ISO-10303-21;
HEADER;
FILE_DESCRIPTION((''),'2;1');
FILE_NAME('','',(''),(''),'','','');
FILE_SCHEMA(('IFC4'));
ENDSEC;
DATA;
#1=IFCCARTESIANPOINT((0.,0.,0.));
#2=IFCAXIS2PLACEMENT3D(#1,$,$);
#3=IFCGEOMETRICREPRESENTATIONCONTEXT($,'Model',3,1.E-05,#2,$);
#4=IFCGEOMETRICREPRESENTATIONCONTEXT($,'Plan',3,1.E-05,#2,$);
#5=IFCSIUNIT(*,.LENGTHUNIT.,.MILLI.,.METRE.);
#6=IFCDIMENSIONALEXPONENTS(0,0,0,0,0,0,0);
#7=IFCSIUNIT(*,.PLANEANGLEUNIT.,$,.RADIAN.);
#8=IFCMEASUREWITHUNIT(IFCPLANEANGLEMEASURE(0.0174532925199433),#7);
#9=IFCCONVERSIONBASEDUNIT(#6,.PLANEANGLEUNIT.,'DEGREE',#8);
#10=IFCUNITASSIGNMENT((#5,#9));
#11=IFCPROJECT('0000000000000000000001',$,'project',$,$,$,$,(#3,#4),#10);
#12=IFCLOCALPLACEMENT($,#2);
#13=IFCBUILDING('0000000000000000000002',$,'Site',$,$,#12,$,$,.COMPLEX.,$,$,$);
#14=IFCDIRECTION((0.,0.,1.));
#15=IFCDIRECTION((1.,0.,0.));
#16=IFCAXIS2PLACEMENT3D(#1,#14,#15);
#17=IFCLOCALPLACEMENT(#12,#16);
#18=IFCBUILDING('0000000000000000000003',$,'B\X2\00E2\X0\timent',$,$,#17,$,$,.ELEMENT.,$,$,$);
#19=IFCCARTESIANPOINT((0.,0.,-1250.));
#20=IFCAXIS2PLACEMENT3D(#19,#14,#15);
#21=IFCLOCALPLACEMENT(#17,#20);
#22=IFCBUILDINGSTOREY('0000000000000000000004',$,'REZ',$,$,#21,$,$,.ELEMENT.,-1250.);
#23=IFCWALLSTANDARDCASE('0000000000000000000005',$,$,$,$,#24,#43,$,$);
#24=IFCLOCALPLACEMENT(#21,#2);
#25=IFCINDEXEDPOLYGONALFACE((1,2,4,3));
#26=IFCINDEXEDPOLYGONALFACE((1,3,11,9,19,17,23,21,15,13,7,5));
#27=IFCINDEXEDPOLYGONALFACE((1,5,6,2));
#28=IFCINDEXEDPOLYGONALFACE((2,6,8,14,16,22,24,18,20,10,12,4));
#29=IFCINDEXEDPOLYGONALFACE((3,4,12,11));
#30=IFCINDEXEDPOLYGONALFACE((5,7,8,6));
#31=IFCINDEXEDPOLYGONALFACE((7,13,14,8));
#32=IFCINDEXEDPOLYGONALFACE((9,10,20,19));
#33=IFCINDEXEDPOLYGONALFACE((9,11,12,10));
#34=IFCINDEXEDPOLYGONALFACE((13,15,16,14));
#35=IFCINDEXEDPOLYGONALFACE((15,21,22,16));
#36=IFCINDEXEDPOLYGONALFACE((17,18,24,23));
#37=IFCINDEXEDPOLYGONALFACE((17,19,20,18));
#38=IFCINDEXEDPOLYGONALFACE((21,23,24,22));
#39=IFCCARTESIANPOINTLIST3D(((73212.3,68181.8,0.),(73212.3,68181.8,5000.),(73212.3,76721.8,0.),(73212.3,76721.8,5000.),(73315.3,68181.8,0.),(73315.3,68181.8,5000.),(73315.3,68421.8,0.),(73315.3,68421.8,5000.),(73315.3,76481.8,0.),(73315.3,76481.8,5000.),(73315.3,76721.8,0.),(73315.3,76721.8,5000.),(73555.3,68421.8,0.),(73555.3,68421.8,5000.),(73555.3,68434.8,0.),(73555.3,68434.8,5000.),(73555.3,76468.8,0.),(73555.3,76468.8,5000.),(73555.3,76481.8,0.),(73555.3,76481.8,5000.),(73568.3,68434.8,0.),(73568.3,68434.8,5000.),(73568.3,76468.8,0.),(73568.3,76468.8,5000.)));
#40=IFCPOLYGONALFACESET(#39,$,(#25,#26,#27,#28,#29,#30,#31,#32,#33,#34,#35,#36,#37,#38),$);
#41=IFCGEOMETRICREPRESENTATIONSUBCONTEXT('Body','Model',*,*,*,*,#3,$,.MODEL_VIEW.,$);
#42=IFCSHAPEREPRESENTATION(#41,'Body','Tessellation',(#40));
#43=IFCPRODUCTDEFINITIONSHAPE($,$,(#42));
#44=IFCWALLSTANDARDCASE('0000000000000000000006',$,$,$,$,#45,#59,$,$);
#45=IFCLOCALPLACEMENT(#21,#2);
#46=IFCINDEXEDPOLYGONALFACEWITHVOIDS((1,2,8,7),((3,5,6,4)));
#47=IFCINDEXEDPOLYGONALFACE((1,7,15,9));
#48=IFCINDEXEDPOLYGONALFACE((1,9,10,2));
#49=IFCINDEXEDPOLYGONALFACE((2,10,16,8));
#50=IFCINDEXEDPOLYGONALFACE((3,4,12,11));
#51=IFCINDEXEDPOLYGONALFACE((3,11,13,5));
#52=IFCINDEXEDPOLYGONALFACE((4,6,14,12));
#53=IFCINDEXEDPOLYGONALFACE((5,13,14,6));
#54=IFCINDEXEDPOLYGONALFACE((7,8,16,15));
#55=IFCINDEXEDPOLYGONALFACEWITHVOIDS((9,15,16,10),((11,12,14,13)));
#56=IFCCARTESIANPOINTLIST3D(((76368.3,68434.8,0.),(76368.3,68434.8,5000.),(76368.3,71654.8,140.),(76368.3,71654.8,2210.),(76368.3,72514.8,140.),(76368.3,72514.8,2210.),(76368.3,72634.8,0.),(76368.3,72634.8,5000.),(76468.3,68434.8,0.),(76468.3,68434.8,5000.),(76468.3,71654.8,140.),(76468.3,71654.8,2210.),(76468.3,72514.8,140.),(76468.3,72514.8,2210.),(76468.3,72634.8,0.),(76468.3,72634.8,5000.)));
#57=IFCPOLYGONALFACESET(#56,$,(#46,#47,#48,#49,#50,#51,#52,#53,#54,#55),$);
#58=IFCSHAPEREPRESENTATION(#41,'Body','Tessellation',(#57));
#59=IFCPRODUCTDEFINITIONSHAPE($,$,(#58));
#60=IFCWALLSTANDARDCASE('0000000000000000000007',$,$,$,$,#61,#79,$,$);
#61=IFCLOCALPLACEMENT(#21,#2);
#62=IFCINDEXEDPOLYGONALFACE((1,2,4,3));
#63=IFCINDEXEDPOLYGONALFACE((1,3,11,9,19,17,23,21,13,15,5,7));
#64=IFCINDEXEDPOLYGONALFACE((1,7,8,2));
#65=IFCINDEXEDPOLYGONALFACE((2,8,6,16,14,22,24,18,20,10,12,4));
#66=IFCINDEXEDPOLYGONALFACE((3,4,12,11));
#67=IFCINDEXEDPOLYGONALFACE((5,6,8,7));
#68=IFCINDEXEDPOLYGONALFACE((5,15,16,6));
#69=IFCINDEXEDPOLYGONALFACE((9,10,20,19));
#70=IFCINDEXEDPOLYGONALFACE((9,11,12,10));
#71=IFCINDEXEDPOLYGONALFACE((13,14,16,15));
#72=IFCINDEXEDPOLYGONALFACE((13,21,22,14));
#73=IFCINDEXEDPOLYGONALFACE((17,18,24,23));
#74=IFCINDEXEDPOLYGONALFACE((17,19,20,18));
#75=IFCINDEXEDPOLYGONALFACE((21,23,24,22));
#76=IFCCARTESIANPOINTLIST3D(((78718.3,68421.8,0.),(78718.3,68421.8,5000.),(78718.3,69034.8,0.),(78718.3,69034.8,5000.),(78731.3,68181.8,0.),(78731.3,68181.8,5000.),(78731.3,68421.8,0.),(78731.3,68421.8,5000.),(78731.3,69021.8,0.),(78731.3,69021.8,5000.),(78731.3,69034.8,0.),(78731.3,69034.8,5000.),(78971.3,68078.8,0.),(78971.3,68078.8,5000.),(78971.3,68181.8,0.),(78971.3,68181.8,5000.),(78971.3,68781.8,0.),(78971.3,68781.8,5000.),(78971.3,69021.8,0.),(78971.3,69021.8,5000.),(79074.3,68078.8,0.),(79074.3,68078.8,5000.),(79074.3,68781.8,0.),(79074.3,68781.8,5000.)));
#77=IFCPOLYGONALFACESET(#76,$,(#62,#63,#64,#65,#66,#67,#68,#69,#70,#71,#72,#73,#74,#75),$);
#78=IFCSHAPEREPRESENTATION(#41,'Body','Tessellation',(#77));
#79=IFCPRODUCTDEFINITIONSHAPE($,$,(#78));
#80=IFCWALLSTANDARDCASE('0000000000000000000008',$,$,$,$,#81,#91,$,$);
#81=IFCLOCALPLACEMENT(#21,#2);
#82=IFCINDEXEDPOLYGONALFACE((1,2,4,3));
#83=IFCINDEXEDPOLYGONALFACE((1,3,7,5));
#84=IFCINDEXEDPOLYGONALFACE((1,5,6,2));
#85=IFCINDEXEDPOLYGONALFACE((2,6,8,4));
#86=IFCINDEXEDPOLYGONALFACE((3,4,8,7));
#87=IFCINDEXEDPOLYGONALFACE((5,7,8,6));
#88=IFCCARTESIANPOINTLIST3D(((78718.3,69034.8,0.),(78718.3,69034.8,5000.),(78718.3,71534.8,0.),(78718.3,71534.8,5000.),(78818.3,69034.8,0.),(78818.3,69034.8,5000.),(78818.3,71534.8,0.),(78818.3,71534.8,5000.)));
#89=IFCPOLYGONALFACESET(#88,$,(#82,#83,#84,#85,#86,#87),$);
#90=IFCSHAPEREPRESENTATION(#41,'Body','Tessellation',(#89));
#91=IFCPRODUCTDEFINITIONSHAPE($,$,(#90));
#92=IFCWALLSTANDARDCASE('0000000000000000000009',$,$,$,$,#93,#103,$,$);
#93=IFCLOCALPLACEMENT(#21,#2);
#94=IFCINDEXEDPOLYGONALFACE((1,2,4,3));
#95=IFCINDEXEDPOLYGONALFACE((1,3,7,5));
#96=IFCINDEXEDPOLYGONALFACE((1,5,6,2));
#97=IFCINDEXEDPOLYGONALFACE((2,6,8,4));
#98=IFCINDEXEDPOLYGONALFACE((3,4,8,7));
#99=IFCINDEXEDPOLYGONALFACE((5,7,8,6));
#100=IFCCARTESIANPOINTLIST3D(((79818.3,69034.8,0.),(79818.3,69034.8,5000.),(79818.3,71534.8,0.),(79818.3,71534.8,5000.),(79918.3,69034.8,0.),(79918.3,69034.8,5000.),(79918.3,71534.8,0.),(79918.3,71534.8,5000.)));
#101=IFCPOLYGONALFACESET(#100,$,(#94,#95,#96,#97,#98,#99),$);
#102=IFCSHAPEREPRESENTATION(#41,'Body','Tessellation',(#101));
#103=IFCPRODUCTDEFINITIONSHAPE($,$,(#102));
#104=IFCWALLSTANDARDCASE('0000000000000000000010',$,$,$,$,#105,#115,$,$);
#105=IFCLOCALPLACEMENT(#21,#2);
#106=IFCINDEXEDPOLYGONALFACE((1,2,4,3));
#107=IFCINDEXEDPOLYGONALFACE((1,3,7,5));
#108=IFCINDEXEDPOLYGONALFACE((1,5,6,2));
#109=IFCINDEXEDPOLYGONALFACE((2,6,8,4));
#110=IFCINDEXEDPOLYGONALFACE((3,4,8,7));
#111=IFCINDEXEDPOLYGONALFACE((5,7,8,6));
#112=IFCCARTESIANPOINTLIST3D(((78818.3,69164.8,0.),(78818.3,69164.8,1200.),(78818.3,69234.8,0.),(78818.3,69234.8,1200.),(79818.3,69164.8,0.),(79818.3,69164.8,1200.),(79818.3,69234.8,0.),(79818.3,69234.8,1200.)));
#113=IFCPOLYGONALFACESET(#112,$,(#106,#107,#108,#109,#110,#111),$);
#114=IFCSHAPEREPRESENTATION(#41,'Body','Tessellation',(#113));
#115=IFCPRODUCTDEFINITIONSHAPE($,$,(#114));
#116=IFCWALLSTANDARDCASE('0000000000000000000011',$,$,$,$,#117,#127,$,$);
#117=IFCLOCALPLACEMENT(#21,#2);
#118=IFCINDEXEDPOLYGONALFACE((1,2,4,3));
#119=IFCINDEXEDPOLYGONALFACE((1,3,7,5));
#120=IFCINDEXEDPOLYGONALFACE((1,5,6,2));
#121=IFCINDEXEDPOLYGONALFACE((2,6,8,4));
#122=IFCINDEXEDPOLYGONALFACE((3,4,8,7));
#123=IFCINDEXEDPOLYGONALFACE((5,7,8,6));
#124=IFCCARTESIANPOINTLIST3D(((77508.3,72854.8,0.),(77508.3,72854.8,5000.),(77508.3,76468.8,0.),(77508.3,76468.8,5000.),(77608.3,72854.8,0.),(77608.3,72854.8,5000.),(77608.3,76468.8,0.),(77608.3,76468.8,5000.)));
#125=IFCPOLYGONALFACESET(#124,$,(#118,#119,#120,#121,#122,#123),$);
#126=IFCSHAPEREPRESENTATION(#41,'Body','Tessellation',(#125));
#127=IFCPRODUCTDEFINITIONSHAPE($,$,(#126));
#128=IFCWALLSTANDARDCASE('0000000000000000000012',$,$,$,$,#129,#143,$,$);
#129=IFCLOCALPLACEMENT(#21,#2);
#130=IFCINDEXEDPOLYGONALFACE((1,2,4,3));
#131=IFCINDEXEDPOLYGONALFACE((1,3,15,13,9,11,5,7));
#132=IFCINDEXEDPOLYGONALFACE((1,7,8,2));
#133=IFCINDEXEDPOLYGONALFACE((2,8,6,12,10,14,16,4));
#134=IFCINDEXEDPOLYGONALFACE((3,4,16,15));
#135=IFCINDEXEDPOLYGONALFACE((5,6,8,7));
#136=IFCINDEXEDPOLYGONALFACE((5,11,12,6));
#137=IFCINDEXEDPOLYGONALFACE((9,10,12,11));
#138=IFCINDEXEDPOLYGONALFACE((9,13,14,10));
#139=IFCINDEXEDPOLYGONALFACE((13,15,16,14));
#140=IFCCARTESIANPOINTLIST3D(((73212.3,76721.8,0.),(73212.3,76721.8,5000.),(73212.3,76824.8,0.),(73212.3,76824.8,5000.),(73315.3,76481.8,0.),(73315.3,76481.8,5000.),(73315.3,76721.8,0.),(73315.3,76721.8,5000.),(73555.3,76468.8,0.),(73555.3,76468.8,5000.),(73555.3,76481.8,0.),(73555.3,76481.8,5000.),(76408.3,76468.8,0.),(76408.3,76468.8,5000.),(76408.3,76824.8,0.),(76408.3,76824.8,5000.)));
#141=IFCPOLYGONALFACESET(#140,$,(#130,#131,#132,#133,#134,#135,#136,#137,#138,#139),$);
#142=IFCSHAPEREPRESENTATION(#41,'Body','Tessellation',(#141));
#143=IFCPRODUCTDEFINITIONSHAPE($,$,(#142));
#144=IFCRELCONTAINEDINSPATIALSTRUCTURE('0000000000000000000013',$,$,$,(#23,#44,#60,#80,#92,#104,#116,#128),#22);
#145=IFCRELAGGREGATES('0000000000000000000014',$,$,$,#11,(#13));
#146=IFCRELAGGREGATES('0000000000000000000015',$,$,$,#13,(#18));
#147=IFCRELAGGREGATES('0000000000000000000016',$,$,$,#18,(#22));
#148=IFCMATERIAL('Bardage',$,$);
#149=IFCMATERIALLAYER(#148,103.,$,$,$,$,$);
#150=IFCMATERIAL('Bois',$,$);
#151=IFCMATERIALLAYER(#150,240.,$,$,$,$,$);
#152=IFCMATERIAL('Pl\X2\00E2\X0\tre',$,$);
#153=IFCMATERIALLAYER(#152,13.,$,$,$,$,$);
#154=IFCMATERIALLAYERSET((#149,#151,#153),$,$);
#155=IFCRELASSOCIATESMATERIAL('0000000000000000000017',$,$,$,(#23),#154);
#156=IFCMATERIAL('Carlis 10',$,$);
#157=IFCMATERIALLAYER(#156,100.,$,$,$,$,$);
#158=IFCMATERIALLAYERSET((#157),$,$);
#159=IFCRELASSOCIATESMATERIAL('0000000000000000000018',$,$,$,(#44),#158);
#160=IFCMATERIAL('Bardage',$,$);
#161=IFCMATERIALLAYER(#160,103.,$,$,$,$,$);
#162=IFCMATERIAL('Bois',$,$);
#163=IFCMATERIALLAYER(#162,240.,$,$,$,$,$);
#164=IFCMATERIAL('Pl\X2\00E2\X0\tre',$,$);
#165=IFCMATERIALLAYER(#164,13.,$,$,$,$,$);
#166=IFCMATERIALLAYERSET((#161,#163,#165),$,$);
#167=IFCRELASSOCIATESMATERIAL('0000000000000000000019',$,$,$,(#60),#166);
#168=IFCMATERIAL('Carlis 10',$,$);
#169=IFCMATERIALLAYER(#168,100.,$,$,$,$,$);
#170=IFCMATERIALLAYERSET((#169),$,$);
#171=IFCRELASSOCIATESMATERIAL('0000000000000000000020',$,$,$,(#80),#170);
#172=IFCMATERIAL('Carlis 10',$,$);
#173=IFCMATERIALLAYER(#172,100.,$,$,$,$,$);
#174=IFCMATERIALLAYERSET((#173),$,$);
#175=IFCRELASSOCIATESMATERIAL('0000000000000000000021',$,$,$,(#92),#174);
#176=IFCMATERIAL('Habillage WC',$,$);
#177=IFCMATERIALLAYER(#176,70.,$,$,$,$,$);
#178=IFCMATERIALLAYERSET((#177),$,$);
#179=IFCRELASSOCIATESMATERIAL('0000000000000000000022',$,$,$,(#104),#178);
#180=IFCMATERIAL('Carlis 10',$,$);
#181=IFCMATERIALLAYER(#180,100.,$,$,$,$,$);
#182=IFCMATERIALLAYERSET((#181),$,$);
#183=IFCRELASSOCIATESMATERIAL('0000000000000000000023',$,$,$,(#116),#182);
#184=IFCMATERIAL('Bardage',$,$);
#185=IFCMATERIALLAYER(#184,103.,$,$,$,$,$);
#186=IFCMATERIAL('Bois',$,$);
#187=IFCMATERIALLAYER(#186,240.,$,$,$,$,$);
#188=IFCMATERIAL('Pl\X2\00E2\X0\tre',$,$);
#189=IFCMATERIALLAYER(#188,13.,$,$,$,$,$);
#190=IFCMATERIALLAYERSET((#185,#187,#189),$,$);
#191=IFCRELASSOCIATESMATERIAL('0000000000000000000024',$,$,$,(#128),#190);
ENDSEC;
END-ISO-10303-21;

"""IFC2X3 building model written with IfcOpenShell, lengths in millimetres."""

from ifc_helpers import new_model, entity, si_unit, converted_unit, frame, frame_2d, origin, origin_with_axes, place, context, subcontext, project, spatial, polyline, rectangle, outline, extrude, material, layer, layer_set, layer_usage, element, save


model = new_model("IFC2X3")

# Units and contexts
model_context = context("Model", 3, precision=1e-05, world=origin())
plan_context = context("Plan", 3, precision=1e-05, world=origin())
body_context = subcontext(model_context, "Body", "Model", "MODEL_VIEW")
ifc_project = project(units=[si_unit("LENGTHUNIT", "METRE", prefix="MILLI"), converted_unit("PLANEANGLEUNIT", "DEGREE", entity("IfcPlaneAngleMeasure", 0.0174532925199433), si_unit("PLANEANGLEUNIT", "RADIAN"), dimensions=[0, 0, 0, 0, 0, 0, 0])], contexts=[model_context, plan_context])

# Buildings, storey
building_1_placement = place(None, origin())
building_1 = spatial("IfcBuilding", under=ifc_project, at=building_1_placement, Name="Site", CompositionType="COMPLEX")
building_2_placement = place(building_1_placement, origin_with_axes())
building_2 = spatial("IfcBuilding", under=building_1, at=building_2_placement, Name="Bâtiment", CompositionType="ELEMENT")
storey_placement = place(building_2_placement, frame((0.0, 0.0, -1250.0), z_axis=(0.0, 0.0, 1.0), x_axis=(1.0, 0.0, 0.0)))
storey = spatial("IfcBuildingStorey", under=building_2, at=storey_placement, Name="REZ", CompositionType="ELEMENT", Elevation=-1250.0)

# Wall
ifc_material_1 = material(Name="Bardage")
ifc_layer_1 = layer(ifc_material_1, 103.0)
ifc_material_2 = material(Name="Bois")
ifc_layer_2 = layer(ifc_material_2, 240.0)
ifc_material_3 = material(Name="Plâtre")
ifc_layer_3 = layer(ifc_material_3, 13.0)
ifc_layer_set_1 = layer_set([ifc_layer_1, ifc_layer_2, ifc_layer_3])
ifc_layer_usage_1 = layer_usage(ifc_layer_set_1, "AXIS2", "POSITIVE", 0.0)
wall_1_placement = place(storey_placement, frame((73212.3, 76721.8, 0.0), z_axis=(0.0, 0.0, 1.0), x_axis=(0.0, -1.0, 0.0)))
element("IfcWallStandardCase", 1, at=wall_1_placement, inside=storey, material=ifc_layer_usage_1, context=body_context, shape_type="SweptSolid", body=[
    extrude(outline(polyline([(0.0, 0.0), (8540.0, 0.0), (8540.0, 103.0), (8300.0, 103.0), (8300.0, 343.0), (8287.0, 343.0), (8287.0, 356.0), (253.0, 356.0), (253.0, 343.0), (240.0, 343.0), (240.0, 103.0), (0.0, 103.0), (0.0, 0.0)])), origin_with_axes(), (0.0, 0.0, 1.0), 5000.0),
])

# Wall, opening
ifc_material_4 = material(Name="Carlis 10")
ifc_layer_4 = layer(ifc_material_4, 100.0)
ifc_layer_set_2 = layer_set([ifc_layer_4])
ifc_layer_usage_2 = layer_usage(ifc_layer_set_2, "AXIS2", "POSITIVE", 0.0)
wall_2_placement = place(storey_placement, frame((76368.3, 72634.8, 0.0), z_axis=(0.0, 0.0, 1.0), x_axis=(0.0, -1.0, 0.0)))
wall_2 = element("IfcWallStandardCase", 2, at=wall_2_placement, inside=storey, material=ifc_layer_usage_2, context=body_context, shape_type="SweptSolid", body=[
    extrude(rectangle(XDim=4200.0, YDim=100.0, at=frame_2d((2100.0, 50.0), x_axis=(1.0, 0.0))), origin_with_axes(), (0.0, 0.0, 1.0), 5000.0),
])
opening_1_placement = place(wall_2_placement, frame((120.0, 0.0, 140.0), z_axis=(0.0, 1.0, 0.0), x_axis=(0.0, 0.0, 1.0)))
element("IfcOpeningElement", 3, at=opening_1_placement, cuts=wall_2, ObjectType="Opening", context=body_context, shape_type="SweptSolid", body=[
    extrude(rectangle(XDim=2070.0, YDim=860.0, at=frame_2d((1035.0, 430.0), x_axis=(1.0, 0.0))), origin_with_axes(), (0.0, 0.0, 1.0), 100.0),
])

# Walls
ifc_material_5 = material(Name="Bardage")
ifc_layer_5 = layer(ifc_material_5, 103.0)
ifc_material_6 = material(Name="Bois")
ifc_layer_6 = layer(ifc_material_6, 240.0)
ifc_material_7 = material(Name="Plâtre")
ifc_layer_7 = layer(ifc_material_7, 13.0)
ifc_layer_set_3 = layer_set([ifc_layer_5, ifc_layer_6, ifc_layer_7])
ifc_layer_usage_3 = layer_usage(ifc_layer_set_3, "AXIS2", "POSITIVE", 0.0)
wall_3_placement = place(storey_placement, frame((79074.3, 68078.8, 0.0), z_axis=(0.0, 0.0, 1.0), x_axis=(0.0, 1.0, 0.0)))
element("IfcWallStandardCase", 4, at=wall_3_placement, inside=storey, material=ifc_layer_usage_3, context=body_context, shape_type="SweptSolid", body=[
    extrude(outline(polyline([(0.0, 0.0), (703.0, 0.0), (703.0, 103.0), (943.0, 103.0), (943.0, 343.0), (956.0, 343.0), (956.0, 356.0), (343.0, 356.0), (343.0, 343.0), (103.0, 343.0), (103.0, 103.0), (0.0, 103.0), (0.0, 0.0)])), origin_with_axes(), (0.0, 0.0, 1.0), 5000.0),
])
ifc_material_8 = material(Name="Carlis 10")
ifc_layer_8 = layer(ifc_material_8, 100.0)
ifc_layer_set_4 = layer_set([ifc_layer_8])
ifc_layer_usage_4 = layer_usage(ifc_layer_set_4, "AXIS2", "POSITIVE", 0.0)
wall_4_placement = place(storey_placement, frame((78718.3, 71534.8, 0.0), z_axis=(0.0, 0.0, 1.0), x_axis=(0.0, -1.0, 0.0)))
element("IfcWallStandardCase", 5, at=wall_4_placement, inside=storey, material=ifc_layer_usage_4, context=body_context, shape_type="SweptSolid", body=[
    extrude(rectangle(XDim=2500.0, YDim=100.0, at=frame_2d((1250.0, 50.0), x_axis=(1.0, 0.0))), origin_with_axes(), (0.0, 0.0, 1.0), 5000.0),
])
ifc_material_9 = material(Name="Carlis 10")
ifc_layer_9 = layer(ifc_material_9, 100.0)
ifc_layer_set_5 = layer_set([ifc_layer_9])
ifc_layer_usage_5 = layer_usage(ifc_layer_set_5, "AXIS2", "POSITIVE", 0.0)
wall_5_placement = place(storey_placement, frame((79818.3, 71534.8, 0.0), z_axis=(0.0, 0.0, 1.0), x_axis=(0.0, -1.0, 0.0)))
element("IfcWallStandardCase", 6, at=wall_5_placement, inside=storey, material=ifc_layer_usage_5, context=body_context, shape_type="SweptSolid", body=[
    extrude(rectangle(XDim=2500.0, YDim=100.0, at=frame_2d((1250.0, 50.0), x_axis=(1.0, 0.0))), origin_with_axes(), (0.0, 0.0, 1.0), 5000.0),
])
ifc_material_10 = material(Name="Habillage WC")
ifc_layer_10 = layer(ifc_material_10, 70.0)
ifc_layer_set_6 = layer_set([ifc_layer_10])
ifc_layer_usage_6 = layer_usage(ifc_layer_set_6, "AXIS2", "POSITIVE", 0.0)
wall_6_placement = place(storey_placement, frame((79818.3, 69234.8, 0.0), z_axis=(0.0, 0.0, 1.0), x_axis=(-1.0, 0.0, 0.0)))
element("IfcWallStandardCase", 7, at=wall_6_placement, inside=storey, material=ifc_layer_usage_6, context=body_context, shape_type="SweptSolid", body=[
    extrude(rectangle(XDim=1000.0, YDim=70.0, at=frame_2d((500.0, 35.0), x_axis=(1.0, 0.0))), origin_with_axes(), (0.0, 0.0, 1.0), 1200.0),
])
ifc_material_11 = material(Name="Carlis 10")
ifc_layer_11 = layer(ifc_material_11, 100.0)
ifc_layer_set_7 = layer_set([ifc_layer_11])
ifc_layer_usage_7 = layer_usage(ifc_layer_set_7, "AXIS2", "POSITIVE", 0.0)
wall_7_placement = place(storey_placement, frame((77508.3, 76468.8, 0.0), z_axis=(0.0, 0.0, 1.0), x_axis=(0.0, -1.0, 0.0)))
element("IfcWallStandardCase", 8, at=wall_7_placement, inside=storey, material=ifc_layer_usage_7, context=body_context, shape_type="SweptSolid", body=[
    extrude(rectangle(XDim=3614.0, YDim=100.0, at=frame_2d((1807.0, 50.0), x_axis=(1.0, 0.0))), origin_with_axes(), (0.0, 0.0, 1.0), 5000.0),
])
ifc_material_12 = material(Name="Bardage")
ifc_layer_12 = layer(ifc_material_12, 103.0)
ifc_material_13 = material(Name="Bois")
ifc_layer_13 = layer(ifc_material_13, 240.0)
ifc_material_14 = material(Name="Plâtre")
ifc_layer_14 = layer(ifc_material_14, 13.0)
ifc_layer_set_8 = layer_set([ifc_layer_12, ifc_layer_13, ifc_layer_14])
ifc_layer_usage_8 = layer_usage(ifc_layer_set_8, "AXIS2", "POSITIVE", 0.0)
wall_8_placement = place(storey_placement, frame((76408.3, 76824.8, 0.0), z_axis=(0.0, 0.0, 1.0), x_axis=(-1.0, 0.0, 0.0)))
element("IfcWallStandardCase", 9, at=wall_8_placement, inside=storey, material=ifc_layer_usage_8, context=body_context, shape_type="SweptSolid", body=[
    extrude(outline(polyline([(0.0, 0.0), (3196.0, 0.0), (3196.0, 103.0), (3093.0, 103.0), (3093.0, 343.0), (2853.0, 343.0), (2853.0, 356.0), (0.0, 356.0), (0.0, 0.0)])), origin_with_axes(), (0.0, 0.0, 1.0), 5000.0),
])

save(model, "model.ifc")
